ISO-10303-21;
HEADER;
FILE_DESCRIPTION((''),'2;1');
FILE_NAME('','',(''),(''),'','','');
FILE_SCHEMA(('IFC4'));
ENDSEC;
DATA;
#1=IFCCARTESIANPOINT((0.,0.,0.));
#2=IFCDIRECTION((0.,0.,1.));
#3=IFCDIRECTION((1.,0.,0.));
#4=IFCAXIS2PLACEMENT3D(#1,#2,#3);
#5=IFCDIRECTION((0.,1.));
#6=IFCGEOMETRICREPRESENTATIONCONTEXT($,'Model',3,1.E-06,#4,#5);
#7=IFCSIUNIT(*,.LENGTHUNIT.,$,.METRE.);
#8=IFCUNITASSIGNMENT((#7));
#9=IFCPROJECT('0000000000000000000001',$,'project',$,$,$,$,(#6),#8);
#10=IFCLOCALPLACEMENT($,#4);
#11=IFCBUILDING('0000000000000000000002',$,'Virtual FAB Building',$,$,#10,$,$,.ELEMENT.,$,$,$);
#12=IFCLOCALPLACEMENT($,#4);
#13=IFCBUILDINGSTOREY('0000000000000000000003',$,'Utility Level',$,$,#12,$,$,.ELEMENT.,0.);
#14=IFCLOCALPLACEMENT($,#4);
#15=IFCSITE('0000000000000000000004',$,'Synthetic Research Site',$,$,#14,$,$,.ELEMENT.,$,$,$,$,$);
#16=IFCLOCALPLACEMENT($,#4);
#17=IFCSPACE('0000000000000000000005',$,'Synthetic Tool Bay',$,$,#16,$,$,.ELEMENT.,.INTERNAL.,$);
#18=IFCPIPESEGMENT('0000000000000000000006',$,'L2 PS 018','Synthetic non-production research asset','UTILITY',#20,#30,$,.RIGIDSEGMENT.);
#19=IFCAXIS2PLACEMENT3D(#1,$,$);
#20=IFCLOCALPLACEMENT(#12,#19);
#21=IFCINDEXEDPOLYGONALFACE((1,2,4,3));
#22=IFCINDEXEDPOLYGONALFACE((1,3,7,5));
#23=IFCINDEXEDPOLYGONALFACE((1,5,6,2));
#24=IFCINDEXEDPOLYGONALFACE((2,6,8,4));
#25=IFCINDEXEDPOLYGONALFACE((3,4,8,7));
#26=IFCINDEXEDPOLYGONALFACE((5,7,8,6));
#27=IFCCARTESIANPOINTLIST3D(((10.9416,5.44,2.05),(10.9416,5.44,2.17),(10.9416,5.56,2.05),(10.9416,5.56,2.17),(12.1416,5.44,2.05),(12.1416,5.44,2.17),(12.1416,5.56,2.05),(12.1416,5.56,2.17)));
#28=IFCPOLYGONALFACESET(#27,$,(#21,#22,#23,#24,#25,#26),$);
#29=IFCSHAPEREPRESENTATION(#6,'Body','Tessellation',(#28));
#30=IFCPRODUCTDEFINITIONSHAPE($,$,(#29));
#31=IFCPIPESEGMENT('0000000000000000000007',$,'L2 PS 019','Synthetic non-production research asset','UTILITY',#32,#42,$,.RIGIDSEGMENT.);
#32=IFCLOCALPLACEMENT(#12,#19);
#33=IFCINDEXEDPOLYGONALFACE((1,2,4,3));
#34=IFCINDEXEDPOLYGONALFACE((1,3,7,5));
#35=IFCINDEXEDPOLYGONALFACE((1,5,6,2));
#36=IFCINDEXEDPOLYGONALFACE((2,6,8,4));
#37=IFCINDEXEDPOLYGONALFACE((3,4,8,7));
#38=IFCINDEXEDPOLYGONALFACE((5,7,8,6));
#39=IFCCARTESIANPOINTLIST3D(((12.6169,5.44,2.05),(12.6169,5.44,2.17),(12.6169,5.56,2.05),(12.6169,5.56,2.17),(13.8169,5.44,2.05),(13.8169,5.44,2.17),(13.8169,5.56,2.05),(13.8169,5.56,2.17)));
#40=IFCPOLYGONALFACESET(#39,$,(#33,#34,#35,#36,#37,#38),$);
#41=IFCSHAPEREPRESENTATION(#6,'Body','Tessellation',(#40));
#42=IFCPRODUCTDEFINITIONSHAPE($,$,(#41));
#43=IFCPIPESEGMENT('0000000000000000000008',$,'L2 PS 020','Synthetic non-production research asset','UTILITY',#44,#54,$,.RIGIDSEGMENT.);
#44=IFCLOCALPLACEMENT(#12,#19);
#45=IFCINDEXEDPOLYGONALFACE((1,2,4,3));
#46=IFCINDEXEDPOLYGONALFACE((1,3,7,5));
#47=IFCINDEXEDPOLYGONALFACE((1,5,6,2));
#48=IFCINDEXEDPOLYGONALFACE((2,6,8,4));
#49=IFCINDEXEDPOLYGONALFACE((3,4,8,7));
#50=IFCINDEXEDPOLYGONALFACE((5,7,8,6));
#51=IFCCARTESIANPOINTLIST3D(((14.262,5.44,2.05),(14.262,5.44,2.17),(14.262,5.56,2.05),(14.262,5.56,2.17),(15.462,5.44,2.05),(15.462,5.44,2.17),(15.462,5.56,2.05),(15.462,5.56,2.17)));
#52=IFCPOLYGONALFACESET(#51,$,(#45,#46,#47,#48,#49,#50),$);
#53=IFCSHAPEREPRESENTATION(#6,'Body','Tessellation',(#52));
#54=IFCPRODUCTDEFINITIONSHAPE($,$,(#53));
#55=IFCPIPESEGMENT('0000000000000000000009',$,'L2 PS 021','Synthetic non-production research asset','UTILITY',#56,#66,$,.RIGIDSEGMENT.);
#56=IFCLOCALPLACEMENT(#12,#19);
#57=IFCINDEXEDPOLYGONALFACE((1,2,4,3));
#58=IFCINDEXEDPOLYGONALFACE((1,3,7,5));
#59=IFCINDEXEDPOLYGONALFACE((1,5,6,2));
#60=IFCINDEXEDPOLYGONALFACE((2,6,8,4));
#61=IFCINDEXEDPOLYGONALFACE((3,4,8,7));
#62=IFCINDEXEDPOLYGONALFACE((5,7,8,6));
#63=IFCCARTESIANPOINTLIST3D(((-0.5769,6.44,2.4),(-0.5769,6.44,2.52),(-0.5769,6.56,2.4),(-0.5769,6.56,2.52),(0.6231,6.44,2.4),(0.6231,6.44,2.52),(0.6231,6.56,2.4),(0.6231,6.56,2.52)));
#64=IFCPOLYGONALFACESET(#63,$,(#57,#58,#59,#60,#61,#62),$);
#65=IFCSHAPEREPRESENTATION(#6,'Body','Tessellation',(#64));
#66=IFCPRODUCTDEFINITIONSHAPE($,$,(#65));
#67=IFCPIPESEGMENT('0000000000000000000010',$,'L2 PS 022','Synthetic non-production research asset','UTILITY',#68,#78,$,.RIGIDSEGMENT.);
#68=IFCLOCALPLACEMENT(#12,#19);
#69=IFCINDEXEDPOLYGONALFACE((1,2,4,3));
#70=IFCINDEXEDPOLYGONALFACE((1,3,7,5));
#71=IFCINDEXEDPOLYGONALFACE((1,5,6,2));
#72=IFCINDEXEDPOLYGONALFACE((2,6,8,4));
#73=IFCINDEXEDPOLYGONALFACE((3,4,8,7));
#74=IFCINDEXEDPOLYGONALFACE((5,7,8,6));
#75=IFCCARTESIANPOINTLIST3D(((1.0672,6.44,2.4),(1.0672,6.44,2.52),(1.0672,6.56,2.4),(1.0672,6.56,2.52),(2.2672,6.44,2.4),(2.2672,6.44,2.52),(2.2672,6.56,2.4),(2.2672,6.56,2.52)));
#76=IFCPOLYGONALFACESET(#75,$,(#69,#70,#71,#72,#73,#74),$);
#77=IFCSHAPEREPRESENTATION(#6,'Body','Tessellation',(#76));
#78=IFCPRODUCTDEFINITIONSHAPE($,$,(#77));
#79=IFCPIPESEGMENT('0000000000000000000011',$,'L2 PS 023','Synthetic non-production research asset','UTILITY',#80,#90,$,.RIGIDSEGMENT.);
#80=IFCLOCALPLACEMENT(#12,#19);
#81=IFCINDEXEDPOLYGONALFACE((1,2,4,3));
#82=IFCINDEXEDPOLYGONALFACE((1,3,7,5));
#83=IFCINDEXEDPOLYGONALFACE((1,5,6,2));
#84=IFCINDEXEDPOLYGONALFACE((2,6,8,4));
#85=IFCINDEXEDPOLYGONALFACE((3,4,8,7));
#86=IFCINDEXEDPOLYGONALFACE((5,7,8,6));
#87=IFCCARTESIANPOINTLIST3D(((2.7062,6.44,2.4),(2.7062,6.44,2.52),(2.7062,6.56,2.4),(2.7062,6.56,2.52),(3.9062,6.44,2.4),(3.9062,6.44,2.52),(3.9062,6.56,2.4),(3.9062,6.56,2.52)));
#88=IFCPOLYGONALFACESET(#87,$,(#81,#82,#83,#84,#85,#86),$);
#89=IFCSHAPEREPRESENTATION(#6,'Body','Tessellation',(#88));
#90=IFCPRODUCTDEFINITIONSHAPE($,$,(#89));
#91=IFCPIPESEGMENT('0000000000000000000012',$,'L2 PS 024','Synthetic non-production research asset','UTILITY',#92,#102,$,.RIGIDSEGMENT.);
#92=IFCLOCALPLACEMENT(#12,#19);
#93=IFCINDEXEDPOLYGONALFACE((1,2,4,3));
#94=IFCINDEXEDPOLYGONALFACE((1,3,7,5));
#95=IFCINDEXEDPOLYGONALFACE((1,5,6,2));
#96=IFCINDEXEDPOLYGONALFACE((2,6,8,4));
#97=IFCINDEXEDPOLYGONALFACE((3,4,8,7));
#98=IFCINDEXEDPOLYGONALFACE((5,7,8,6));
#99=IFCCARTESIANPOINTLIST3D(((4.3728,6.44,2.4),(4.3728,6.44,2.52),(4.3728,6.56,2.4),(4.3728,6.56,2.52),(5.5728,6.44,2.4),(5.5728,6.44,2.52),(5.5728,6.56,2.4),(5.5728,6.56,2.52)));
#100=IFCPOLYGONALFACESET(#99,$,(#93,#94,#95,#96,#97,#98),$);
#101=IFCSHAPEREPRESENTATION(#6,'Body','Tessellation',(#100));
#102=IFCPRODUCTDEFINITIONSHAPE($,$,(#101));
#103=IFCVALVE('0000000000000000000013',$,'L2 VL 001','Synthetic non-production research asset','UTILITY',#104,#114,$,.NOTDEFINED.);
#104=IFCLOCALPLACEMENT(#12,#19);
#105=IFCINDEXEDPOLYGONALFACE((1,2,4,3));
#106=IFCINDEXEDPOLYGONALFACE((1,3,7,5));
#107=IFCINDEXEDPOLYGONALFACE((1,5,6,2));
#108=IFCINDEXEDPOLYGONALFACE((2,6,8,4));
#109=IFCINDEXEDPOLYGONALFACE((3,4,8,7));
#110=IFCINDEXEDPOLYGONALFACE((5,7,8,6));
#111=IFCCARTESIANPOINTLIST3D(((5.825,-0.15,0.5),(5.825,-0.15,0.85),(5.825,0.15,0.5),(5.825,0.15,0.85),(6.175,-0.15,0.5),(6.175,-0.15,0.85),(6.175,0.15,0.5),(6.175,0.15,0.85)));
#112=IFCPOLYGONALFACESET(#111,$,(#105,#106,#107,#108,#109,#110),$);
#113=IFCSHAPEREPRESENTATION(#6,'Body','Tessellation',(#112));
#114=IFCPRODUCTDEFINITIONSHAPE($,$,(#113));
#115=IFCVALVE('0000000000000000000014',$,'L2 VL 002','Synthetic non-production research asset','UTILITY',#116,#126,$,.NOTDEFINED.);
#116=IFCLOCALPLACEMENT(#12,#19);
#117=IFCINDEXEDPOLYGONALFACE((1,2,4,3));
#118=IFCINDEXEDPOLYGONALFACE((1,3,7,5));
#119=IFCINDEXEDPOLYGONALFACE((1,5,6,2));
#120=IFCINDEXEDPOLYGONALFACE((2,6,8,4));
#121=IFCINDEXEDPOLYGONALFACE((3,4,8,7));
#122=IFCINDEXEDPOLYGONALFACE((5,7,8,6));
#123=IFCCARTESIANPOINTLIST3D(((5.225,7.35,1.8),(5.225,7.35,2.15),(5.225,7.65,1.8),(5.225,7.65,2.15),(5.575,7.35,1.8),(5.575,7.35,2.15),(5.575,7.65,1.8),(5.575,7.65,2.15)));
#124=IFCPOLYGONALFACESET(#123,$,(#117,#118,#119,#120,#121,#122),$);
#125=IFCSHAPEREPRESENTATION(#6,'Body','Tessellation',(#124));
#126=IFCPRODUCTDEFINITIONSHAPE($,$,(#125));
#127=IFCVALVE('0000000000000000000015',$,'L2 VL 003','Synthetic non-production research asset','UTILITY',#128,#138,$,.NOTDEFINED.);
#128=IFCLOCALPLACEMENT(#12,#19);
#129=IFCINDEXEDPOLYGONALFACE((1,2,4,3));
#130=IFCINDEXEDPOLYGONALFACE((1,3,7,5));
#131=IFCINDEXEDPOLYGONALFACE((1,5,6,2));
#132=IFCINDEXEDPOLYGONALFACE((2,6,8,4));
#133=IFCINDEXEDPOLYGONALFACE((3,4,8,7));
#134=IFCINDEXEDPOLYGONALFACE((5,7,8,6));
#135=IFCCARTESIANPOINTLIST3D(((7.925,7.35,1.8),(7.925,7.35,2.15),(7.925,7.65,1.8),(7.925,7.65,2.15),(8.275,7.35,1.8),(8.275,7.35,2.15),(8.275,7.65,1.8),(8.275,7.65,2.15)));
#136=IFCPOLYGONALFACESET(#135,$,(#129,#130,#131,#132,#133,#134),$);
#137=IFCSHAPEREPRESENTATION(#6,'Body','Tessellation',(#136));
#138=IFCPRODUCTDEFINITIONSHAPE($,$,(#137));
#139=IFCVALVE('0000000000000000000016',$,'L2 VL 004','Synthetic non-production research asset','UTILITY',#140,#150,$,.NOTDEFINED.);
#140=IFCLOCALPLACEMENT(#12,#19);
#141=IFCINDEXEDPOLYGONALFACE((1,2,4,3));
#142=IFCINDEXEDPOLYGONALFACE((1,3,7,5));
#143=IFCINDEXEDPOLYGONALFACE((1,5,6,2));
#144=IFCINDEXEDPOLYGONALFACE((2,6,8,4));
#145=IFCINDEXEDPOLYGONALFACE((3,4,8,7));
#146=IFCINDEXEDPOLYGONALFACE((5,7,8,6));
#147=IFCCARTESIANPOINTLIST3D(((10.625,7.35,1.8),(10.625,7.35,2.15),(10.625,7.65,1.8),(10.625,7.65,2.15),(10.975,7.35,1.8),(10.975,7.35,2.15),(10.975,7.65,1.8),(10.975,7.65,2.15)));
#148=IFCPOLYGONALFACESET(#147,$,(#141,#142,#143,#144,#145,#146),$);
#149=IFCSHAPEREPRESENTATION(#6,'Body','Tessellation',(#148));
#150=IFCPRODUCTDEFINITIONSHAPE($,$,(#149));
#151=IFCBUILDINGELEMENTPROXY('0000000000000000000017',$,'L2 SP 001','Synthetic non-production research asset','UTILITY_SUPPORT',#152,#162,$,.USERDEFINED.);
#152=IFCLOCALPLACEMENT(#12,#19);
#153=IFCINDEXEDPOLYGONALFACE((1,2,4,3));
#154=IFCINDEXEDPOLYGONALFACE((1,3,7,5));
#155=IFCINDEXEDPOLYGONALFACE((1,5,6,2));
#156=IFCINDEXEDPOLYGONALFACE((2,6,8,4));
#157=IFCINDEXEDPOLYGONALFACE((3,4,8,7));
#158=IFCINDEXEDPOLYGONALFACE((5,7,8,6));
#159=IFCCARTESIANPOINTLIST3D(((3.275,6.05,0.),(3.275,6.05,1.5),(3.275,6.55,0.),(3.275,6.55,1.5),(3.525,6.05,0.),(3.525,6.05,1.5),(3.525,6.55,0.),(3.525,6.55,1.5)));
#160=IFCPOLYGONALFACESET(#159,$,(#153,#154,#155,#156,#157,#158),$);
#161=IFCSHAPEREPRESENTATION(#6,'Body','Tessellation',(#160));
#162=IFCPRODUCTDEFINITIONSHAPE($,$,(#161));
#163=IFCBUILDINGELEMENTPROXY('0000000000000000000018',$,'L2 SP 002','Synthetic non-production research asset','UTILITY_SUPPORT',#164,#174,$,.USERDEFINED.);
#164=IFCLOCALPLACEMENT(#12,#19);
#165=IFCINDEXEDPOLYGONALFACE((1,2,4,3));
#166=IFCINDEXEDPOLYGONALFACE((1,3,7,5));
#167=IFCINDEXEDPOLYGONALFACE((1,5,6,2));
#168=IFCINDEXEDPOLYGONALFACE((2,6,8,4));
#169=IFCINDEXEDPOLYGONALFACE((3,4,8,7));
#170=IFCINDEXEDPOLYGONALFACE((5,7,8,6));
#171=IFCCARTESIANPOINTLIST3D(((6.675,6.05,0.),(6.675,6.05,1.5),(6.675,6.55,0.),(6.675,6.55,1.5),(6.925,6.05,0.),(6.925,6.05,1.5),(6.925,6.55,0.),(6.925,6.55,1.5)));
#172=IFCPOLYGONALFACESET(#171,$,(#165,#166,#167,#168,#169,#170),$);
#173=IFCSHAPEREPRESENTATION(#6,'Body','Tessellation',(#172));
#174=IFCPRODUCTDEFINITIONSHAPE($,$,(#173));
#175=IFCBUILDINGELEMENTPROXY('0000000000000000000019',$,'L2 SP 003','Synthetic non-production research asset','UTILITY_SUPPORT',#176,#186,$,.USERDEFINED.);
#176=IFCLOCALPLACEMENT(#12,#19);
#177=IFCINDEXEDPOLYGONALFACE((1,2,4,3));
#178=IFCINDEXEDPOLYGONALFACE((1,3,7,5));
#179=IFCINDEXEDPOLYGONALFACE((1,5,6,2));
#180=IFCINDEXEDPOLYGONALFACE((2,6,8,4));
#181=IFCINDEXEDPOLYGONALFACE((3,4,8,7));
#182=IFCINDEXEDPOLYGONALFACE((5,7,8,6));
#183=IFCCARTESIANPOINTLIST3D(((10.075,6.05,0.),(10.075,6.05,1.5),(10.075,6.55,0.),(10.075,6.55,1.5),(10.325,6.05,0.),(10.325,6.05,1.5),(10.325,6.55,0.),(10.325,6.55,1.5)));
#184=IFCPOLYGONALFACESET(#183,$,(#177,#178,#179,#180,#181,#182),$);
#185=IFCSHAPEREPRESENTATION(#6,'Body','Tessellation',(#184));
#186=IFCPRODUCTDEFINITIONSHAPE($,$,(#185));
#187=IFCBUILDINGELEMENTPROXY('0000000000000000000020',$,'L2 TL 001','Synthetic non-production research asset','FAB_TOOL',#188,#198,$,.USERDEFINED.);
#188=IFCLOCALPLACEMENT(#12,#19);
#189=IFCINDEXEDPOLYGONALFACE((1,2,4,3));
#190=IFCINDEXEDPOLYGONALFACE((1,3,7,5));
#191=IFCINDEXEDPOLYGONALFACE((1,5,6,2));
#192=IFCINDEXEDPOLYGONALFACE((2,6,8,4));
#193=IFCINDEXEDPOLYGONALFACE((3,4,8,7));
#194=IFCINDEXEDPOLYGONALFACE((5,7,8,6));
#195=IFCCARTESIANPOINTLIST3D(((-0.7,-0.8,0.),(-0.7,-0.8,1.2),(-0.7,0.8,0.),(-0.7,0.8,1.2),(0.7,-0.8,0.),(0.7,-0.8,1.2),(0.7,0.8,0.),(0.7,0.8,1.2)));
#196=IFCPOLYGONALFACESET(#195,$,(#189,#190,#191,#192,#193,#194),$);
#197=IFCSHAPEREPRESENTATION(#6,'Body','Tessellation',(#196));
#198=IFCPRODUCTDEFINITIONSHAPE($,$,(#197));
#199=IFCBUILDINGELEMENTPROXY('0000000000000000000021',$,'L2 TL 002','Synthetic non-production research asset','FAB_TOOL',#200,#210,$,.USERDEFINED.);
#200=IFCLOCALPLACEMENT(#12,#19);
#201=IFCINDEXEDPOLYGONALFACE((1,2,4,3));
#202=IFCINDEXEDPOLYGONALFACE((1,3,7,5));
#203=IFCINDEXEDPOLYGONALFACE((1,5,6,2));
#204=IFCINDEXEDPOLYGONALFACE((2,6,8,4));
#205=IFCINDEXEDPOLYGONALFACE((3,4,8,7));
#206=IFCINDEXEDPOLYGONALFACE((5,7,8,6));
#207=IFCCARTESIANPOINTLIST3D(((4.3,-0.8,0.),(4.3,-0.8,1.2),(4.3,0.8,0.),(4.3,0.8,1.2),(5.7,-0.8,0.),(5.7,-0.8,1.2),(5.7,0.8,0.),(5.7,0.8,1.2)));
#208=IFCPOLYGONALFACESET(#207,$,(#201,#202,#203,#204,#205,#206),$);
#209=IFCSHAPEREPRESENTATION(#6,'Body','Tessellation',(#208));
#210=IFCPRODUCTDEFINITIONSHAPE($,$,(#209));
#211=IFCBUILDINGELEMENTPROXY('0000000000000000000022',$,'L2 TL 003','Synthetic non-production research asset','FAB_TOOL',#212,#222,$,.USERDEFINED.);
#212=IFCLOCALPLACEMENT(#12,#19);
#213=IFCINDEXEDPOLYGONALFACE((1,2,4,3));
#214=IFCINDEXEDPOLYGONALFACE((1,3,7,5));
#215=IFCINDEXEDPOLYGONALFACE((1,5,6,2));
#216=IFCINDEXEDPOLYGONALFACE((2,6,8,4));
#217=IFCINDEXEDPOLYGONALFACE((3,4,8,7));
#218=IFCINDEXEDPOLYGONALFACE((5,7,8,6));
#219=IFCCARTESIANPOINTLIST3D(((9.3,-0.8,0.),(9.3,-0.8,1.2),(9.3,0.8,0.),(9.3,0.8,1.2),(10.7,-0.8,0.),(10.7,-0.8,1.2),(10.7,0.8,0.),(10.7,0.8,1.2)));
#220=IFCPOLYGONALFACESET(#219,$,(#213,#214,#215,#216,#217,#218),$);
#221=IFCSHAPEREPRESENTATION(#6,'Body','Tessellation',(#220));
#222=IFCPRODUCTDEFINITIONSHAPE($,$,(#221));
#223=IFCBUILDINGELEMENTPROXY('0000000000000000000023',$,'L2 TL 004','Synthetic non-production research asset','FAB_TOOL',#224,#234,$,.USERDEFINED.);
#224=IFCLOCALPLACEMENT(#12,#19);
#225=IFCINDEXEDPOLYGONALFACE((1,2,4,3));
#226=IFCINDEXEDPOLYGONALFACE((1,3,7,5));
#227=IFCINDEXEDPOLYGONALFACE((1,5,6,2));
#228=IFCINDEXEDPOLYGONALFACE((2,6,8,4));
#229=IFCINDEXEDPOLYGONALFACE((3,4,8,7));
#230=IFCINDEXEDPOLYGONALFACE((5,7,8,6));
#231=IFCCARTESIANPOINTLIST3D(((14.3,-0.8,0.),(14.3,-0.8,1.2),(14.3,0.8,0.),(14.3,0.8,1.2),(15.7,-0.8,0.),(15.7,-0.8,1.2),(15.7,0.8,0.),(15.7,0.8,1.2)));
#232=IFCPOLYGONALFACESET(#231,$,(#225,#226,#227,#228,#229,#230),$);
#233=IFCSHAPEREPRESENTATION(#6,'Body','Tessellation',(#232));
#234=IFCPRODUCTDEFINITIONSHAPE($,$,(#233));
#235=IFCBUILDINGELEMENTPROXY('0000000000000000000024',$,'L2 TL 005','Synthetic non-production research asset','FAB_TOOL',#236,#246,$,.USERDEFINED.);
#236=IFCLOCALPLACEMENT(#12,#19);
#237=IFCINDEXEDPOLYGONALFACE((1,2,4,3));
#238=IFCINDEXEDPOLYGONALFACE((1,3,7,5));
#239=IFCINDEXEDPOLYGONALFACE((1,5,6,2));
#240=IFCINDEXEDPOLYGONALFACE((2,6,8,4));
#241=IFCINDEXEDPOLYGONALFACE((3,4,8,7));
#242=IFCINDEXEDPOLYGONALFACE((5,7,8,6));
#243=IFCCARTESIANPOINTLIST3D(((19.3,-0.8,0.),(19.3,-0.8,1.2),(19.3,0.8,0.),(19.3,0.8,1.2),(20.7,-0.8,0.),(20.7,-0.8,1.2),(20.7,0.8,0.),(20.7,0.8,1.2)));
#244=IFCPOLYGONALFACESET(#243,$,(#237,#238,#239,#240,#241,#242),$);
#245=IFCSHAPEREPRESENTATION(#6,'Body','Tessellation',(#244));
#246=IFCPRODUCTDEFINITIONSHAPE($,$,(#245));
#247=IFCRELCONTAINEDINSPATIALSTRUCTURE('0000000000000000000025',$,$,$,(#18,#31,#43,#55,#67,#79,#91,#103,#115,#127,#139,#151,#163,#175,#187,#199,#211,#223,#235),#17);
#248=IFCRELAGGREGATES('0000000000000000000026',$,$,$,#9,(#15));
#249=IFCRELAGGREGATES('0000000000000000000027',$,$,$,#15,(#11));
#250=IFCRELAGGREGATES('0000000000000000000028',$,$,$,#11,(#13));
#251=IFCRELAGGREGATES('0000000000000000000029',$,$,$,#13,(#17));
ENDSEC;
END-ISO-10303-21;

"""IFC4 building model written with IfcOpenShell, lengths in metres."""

from ifc_helpers import new_model, si_unit, direction, frame, origin_with_axes, origin_2d_with_axis, place, context, project, spatial, rectangle, extrude, element, save


model = new_model("IFC4")

# Units and contexts
model_context = context("Model", 3, precision=1e-06, world=origin_with_axes(), true_north=direction((0.0, 1.0)))
ifc_project = project(units=[si_unit("LENGTHUNIT", "METRE")], contexts=[model_context])

# Site, building, storey, space
site_placement = place(None, origin_with_axes())
site = spatial("IfcSite", under=ifc_project, at=site_placement, Name="Synthetic Research Site", CompositionType="ELEMENT")
building_placement = place(None, origin_with_axes())
building = spatial("IfcBuilding", under=site, at=building_placement, Name="Virtual FAB Building", CompositionType="ELEMENT")
storey_placement = place(None, origin_with_axes())
storey = spatial("IfcBuildingStorey", under=building, at=storey_placement, Name="Utility Level", CompositionType="ELEMENT", Elevation=0.0)
space_placement = place(None, origin_with_axes())
space = spatial("IfcSpace", under=storey, at=space_placement, Name="Synthetic Tool Bay", CompositionType="ELEMENT", PredefinedType="INTERNAL")

# Pipe segments
for number, where, z_axis, x_axis, name in (
    (1, (11.5416, 5.5, 2.05), (0.0, 0.0, 1.0), (1.0, 0.0, 0.0), "L2 PS 018"),
    (2, (13.2169, 5.5, 2.05), (0.0, 0.0, 1.0), (1.0, 0.0, 0.0), "L2 PS 019"),
    (3, (14.862, 5.5, 2.05), (0.0, 0.0, 1.0), (1.0, 0.0, 0.0), "L2 PS 020"),
    (4, (0.0231, 6.5, 2.4), (0.0, 0.0, 1.0), (1.0, 0.0, 0.0), "L2 PS 021"),
    (5, (1.6672, 6.5, 2.4), (0.0, 0.0, 1.0), (1.0, 0.0, 0.0), "L2 PS 022"),
    (6, (3.3062, 6.5, 2.4), (0.0, 0.0, 1.0), (1.0, 0.0, 0.0), "L2 PS 023"),
    (7, (4.9728, 6.5, 2.4), (0.0, 0.0, 1.0), (1.0, 0.0, 0.0), "L2 PS 024"),
):
    element("IfcPipeSegment", number, at=place(None, frame(where, z_axis=z_axis, x_axis=x_axis)), inside=space, Name=name, Description="Synthetic non-production research asset", ObjectType="UTILITY", PredefinedType="RIGIDSEGMENT", context=model_context, shape_type="SweptSolid", body=[
        extrude(rectangle(XDim=1.2, YDim=0.12, at=origin_2d_with_axis()), origin_with_axes(), (0.0, 0.0, 1.0), 0.12),
    ])

# Valves
for number, where, z_axis, x_axis, name in (
    (8, (6.0, 0.0, 0.5), (0.0, 0.0, 1.0), (1.0, 0.0, 0.0), "L2 VL 001"),
    (9, (5.4, 7.5, 1.8), (0.0, 0.0, 1.0), (1.0, 0.0, 0.0), "L2 VL 002"),
    (10, (8.1, 7.5, 1.8), (0.0, 0.0, 1.0), (1.0, 0.0, 0.0), "L2 VL 003"),
    (11, (10.8, 7.5, 1.8), (0.0, 0.0, 1.0), (1.0, 0.0, 0.0), "L2 VL 004"),
):
    element("IfcValve", number, at=place(None, frame(where, z_axis=z_axis, x_axis=x_axis)), inside=space, Name=name, Description="Synthetic non-production research asset", ObjectType="UTILITY", PredefinedType="NOTDEFINED", context=model_context, shape_type="SweptSolid", body=[
        extrude(rectangle(XDim=0.35, YDim=0.3, at=origin_2d_with_axis()), origin_with_axes(), (0.0, 0.0, 1.0), 0.35),
    ])

# Building element proxies
for number, where, z_axis, x_axis, name in (
    (12, (3.4, 6.3, 0.0), (0.0, 0.0, 1.0), (1.0, 0.0, 0.0), "L2 SP 001"),
    (13, (6.8, 6.3, 0.0), (0.0, 0.0, 1.0), (1.0, 0.0, 0.0), "L2 SP 002"),
    (14, (10.2, 6.3, 0.0), (0.0, 0.0, 1.0), (1.0, 0.0, 0.0), "L2 SP 003"),
):
    element("IfcBuildingElementProxy", number, at=place(None, frame(where, z_axis=z_axis, x_axis=x_axis)), inside=space, Name=name, Description="Synthetic non-production research asset", ObjectType="UTILITY_SUPPORT", PredefinedType="USERDEFINED", context=model_context, shape_type="SweptSolid", body=[
        extrude(rectangle(XDim=0.25, YDim=0.5, at=origin_2d_with_axis()), origin_with_axes(), (0.0, 0.0, 1.0), 1.5),
    ])
for number, where, z_axis, x_axis, name in (
    (15, (0.0, 0.0, 0.0), (0.0, 0.0, 1.0), (1.0, 0.0, 0.0), "L2 TL 001"),
    (16, (5.0, 0.0, 0.0), (0.0, 0.0, 1.0), (1.0, 0.0, 0.0), "L2 TL 002"),
    (17, (10.0, 0.0, 0.0), (0.0, 0.0, 1.0), (1.0, 0.0, 0.0), "L2 TL 003"),
    (18, (15.0, 0.0, 0.0), (0.0, 0.0, 1.0), (1.0, 0.0, 0.0), "L2 TL 004"),
    (19, (20.0, 0.0, 0.0), (0.0, 0.0, 1.0), (1.0, 0.0, 0.0), "L2 TL 005"),
):
    element("IfcBuildingElementProxy", number, at=place(None, frame(where, z_axis=z_axis, x_axis=x_axis)), inside=space, Name=name, Description="Synthetic non-production research asset", ObjectType="FAB_TOOL", PredefinedType="USERDEFINED", context=model_context, shape_type="SweptSolid", body=[
        extrude(rectangle(XDim=1.4, YDim=1.6, at=origin_2d_with_axis()), origin_with_axes(), (0.0, 0.0, 1.0), 1.2),
    ])

save(model, "model.ifc")
